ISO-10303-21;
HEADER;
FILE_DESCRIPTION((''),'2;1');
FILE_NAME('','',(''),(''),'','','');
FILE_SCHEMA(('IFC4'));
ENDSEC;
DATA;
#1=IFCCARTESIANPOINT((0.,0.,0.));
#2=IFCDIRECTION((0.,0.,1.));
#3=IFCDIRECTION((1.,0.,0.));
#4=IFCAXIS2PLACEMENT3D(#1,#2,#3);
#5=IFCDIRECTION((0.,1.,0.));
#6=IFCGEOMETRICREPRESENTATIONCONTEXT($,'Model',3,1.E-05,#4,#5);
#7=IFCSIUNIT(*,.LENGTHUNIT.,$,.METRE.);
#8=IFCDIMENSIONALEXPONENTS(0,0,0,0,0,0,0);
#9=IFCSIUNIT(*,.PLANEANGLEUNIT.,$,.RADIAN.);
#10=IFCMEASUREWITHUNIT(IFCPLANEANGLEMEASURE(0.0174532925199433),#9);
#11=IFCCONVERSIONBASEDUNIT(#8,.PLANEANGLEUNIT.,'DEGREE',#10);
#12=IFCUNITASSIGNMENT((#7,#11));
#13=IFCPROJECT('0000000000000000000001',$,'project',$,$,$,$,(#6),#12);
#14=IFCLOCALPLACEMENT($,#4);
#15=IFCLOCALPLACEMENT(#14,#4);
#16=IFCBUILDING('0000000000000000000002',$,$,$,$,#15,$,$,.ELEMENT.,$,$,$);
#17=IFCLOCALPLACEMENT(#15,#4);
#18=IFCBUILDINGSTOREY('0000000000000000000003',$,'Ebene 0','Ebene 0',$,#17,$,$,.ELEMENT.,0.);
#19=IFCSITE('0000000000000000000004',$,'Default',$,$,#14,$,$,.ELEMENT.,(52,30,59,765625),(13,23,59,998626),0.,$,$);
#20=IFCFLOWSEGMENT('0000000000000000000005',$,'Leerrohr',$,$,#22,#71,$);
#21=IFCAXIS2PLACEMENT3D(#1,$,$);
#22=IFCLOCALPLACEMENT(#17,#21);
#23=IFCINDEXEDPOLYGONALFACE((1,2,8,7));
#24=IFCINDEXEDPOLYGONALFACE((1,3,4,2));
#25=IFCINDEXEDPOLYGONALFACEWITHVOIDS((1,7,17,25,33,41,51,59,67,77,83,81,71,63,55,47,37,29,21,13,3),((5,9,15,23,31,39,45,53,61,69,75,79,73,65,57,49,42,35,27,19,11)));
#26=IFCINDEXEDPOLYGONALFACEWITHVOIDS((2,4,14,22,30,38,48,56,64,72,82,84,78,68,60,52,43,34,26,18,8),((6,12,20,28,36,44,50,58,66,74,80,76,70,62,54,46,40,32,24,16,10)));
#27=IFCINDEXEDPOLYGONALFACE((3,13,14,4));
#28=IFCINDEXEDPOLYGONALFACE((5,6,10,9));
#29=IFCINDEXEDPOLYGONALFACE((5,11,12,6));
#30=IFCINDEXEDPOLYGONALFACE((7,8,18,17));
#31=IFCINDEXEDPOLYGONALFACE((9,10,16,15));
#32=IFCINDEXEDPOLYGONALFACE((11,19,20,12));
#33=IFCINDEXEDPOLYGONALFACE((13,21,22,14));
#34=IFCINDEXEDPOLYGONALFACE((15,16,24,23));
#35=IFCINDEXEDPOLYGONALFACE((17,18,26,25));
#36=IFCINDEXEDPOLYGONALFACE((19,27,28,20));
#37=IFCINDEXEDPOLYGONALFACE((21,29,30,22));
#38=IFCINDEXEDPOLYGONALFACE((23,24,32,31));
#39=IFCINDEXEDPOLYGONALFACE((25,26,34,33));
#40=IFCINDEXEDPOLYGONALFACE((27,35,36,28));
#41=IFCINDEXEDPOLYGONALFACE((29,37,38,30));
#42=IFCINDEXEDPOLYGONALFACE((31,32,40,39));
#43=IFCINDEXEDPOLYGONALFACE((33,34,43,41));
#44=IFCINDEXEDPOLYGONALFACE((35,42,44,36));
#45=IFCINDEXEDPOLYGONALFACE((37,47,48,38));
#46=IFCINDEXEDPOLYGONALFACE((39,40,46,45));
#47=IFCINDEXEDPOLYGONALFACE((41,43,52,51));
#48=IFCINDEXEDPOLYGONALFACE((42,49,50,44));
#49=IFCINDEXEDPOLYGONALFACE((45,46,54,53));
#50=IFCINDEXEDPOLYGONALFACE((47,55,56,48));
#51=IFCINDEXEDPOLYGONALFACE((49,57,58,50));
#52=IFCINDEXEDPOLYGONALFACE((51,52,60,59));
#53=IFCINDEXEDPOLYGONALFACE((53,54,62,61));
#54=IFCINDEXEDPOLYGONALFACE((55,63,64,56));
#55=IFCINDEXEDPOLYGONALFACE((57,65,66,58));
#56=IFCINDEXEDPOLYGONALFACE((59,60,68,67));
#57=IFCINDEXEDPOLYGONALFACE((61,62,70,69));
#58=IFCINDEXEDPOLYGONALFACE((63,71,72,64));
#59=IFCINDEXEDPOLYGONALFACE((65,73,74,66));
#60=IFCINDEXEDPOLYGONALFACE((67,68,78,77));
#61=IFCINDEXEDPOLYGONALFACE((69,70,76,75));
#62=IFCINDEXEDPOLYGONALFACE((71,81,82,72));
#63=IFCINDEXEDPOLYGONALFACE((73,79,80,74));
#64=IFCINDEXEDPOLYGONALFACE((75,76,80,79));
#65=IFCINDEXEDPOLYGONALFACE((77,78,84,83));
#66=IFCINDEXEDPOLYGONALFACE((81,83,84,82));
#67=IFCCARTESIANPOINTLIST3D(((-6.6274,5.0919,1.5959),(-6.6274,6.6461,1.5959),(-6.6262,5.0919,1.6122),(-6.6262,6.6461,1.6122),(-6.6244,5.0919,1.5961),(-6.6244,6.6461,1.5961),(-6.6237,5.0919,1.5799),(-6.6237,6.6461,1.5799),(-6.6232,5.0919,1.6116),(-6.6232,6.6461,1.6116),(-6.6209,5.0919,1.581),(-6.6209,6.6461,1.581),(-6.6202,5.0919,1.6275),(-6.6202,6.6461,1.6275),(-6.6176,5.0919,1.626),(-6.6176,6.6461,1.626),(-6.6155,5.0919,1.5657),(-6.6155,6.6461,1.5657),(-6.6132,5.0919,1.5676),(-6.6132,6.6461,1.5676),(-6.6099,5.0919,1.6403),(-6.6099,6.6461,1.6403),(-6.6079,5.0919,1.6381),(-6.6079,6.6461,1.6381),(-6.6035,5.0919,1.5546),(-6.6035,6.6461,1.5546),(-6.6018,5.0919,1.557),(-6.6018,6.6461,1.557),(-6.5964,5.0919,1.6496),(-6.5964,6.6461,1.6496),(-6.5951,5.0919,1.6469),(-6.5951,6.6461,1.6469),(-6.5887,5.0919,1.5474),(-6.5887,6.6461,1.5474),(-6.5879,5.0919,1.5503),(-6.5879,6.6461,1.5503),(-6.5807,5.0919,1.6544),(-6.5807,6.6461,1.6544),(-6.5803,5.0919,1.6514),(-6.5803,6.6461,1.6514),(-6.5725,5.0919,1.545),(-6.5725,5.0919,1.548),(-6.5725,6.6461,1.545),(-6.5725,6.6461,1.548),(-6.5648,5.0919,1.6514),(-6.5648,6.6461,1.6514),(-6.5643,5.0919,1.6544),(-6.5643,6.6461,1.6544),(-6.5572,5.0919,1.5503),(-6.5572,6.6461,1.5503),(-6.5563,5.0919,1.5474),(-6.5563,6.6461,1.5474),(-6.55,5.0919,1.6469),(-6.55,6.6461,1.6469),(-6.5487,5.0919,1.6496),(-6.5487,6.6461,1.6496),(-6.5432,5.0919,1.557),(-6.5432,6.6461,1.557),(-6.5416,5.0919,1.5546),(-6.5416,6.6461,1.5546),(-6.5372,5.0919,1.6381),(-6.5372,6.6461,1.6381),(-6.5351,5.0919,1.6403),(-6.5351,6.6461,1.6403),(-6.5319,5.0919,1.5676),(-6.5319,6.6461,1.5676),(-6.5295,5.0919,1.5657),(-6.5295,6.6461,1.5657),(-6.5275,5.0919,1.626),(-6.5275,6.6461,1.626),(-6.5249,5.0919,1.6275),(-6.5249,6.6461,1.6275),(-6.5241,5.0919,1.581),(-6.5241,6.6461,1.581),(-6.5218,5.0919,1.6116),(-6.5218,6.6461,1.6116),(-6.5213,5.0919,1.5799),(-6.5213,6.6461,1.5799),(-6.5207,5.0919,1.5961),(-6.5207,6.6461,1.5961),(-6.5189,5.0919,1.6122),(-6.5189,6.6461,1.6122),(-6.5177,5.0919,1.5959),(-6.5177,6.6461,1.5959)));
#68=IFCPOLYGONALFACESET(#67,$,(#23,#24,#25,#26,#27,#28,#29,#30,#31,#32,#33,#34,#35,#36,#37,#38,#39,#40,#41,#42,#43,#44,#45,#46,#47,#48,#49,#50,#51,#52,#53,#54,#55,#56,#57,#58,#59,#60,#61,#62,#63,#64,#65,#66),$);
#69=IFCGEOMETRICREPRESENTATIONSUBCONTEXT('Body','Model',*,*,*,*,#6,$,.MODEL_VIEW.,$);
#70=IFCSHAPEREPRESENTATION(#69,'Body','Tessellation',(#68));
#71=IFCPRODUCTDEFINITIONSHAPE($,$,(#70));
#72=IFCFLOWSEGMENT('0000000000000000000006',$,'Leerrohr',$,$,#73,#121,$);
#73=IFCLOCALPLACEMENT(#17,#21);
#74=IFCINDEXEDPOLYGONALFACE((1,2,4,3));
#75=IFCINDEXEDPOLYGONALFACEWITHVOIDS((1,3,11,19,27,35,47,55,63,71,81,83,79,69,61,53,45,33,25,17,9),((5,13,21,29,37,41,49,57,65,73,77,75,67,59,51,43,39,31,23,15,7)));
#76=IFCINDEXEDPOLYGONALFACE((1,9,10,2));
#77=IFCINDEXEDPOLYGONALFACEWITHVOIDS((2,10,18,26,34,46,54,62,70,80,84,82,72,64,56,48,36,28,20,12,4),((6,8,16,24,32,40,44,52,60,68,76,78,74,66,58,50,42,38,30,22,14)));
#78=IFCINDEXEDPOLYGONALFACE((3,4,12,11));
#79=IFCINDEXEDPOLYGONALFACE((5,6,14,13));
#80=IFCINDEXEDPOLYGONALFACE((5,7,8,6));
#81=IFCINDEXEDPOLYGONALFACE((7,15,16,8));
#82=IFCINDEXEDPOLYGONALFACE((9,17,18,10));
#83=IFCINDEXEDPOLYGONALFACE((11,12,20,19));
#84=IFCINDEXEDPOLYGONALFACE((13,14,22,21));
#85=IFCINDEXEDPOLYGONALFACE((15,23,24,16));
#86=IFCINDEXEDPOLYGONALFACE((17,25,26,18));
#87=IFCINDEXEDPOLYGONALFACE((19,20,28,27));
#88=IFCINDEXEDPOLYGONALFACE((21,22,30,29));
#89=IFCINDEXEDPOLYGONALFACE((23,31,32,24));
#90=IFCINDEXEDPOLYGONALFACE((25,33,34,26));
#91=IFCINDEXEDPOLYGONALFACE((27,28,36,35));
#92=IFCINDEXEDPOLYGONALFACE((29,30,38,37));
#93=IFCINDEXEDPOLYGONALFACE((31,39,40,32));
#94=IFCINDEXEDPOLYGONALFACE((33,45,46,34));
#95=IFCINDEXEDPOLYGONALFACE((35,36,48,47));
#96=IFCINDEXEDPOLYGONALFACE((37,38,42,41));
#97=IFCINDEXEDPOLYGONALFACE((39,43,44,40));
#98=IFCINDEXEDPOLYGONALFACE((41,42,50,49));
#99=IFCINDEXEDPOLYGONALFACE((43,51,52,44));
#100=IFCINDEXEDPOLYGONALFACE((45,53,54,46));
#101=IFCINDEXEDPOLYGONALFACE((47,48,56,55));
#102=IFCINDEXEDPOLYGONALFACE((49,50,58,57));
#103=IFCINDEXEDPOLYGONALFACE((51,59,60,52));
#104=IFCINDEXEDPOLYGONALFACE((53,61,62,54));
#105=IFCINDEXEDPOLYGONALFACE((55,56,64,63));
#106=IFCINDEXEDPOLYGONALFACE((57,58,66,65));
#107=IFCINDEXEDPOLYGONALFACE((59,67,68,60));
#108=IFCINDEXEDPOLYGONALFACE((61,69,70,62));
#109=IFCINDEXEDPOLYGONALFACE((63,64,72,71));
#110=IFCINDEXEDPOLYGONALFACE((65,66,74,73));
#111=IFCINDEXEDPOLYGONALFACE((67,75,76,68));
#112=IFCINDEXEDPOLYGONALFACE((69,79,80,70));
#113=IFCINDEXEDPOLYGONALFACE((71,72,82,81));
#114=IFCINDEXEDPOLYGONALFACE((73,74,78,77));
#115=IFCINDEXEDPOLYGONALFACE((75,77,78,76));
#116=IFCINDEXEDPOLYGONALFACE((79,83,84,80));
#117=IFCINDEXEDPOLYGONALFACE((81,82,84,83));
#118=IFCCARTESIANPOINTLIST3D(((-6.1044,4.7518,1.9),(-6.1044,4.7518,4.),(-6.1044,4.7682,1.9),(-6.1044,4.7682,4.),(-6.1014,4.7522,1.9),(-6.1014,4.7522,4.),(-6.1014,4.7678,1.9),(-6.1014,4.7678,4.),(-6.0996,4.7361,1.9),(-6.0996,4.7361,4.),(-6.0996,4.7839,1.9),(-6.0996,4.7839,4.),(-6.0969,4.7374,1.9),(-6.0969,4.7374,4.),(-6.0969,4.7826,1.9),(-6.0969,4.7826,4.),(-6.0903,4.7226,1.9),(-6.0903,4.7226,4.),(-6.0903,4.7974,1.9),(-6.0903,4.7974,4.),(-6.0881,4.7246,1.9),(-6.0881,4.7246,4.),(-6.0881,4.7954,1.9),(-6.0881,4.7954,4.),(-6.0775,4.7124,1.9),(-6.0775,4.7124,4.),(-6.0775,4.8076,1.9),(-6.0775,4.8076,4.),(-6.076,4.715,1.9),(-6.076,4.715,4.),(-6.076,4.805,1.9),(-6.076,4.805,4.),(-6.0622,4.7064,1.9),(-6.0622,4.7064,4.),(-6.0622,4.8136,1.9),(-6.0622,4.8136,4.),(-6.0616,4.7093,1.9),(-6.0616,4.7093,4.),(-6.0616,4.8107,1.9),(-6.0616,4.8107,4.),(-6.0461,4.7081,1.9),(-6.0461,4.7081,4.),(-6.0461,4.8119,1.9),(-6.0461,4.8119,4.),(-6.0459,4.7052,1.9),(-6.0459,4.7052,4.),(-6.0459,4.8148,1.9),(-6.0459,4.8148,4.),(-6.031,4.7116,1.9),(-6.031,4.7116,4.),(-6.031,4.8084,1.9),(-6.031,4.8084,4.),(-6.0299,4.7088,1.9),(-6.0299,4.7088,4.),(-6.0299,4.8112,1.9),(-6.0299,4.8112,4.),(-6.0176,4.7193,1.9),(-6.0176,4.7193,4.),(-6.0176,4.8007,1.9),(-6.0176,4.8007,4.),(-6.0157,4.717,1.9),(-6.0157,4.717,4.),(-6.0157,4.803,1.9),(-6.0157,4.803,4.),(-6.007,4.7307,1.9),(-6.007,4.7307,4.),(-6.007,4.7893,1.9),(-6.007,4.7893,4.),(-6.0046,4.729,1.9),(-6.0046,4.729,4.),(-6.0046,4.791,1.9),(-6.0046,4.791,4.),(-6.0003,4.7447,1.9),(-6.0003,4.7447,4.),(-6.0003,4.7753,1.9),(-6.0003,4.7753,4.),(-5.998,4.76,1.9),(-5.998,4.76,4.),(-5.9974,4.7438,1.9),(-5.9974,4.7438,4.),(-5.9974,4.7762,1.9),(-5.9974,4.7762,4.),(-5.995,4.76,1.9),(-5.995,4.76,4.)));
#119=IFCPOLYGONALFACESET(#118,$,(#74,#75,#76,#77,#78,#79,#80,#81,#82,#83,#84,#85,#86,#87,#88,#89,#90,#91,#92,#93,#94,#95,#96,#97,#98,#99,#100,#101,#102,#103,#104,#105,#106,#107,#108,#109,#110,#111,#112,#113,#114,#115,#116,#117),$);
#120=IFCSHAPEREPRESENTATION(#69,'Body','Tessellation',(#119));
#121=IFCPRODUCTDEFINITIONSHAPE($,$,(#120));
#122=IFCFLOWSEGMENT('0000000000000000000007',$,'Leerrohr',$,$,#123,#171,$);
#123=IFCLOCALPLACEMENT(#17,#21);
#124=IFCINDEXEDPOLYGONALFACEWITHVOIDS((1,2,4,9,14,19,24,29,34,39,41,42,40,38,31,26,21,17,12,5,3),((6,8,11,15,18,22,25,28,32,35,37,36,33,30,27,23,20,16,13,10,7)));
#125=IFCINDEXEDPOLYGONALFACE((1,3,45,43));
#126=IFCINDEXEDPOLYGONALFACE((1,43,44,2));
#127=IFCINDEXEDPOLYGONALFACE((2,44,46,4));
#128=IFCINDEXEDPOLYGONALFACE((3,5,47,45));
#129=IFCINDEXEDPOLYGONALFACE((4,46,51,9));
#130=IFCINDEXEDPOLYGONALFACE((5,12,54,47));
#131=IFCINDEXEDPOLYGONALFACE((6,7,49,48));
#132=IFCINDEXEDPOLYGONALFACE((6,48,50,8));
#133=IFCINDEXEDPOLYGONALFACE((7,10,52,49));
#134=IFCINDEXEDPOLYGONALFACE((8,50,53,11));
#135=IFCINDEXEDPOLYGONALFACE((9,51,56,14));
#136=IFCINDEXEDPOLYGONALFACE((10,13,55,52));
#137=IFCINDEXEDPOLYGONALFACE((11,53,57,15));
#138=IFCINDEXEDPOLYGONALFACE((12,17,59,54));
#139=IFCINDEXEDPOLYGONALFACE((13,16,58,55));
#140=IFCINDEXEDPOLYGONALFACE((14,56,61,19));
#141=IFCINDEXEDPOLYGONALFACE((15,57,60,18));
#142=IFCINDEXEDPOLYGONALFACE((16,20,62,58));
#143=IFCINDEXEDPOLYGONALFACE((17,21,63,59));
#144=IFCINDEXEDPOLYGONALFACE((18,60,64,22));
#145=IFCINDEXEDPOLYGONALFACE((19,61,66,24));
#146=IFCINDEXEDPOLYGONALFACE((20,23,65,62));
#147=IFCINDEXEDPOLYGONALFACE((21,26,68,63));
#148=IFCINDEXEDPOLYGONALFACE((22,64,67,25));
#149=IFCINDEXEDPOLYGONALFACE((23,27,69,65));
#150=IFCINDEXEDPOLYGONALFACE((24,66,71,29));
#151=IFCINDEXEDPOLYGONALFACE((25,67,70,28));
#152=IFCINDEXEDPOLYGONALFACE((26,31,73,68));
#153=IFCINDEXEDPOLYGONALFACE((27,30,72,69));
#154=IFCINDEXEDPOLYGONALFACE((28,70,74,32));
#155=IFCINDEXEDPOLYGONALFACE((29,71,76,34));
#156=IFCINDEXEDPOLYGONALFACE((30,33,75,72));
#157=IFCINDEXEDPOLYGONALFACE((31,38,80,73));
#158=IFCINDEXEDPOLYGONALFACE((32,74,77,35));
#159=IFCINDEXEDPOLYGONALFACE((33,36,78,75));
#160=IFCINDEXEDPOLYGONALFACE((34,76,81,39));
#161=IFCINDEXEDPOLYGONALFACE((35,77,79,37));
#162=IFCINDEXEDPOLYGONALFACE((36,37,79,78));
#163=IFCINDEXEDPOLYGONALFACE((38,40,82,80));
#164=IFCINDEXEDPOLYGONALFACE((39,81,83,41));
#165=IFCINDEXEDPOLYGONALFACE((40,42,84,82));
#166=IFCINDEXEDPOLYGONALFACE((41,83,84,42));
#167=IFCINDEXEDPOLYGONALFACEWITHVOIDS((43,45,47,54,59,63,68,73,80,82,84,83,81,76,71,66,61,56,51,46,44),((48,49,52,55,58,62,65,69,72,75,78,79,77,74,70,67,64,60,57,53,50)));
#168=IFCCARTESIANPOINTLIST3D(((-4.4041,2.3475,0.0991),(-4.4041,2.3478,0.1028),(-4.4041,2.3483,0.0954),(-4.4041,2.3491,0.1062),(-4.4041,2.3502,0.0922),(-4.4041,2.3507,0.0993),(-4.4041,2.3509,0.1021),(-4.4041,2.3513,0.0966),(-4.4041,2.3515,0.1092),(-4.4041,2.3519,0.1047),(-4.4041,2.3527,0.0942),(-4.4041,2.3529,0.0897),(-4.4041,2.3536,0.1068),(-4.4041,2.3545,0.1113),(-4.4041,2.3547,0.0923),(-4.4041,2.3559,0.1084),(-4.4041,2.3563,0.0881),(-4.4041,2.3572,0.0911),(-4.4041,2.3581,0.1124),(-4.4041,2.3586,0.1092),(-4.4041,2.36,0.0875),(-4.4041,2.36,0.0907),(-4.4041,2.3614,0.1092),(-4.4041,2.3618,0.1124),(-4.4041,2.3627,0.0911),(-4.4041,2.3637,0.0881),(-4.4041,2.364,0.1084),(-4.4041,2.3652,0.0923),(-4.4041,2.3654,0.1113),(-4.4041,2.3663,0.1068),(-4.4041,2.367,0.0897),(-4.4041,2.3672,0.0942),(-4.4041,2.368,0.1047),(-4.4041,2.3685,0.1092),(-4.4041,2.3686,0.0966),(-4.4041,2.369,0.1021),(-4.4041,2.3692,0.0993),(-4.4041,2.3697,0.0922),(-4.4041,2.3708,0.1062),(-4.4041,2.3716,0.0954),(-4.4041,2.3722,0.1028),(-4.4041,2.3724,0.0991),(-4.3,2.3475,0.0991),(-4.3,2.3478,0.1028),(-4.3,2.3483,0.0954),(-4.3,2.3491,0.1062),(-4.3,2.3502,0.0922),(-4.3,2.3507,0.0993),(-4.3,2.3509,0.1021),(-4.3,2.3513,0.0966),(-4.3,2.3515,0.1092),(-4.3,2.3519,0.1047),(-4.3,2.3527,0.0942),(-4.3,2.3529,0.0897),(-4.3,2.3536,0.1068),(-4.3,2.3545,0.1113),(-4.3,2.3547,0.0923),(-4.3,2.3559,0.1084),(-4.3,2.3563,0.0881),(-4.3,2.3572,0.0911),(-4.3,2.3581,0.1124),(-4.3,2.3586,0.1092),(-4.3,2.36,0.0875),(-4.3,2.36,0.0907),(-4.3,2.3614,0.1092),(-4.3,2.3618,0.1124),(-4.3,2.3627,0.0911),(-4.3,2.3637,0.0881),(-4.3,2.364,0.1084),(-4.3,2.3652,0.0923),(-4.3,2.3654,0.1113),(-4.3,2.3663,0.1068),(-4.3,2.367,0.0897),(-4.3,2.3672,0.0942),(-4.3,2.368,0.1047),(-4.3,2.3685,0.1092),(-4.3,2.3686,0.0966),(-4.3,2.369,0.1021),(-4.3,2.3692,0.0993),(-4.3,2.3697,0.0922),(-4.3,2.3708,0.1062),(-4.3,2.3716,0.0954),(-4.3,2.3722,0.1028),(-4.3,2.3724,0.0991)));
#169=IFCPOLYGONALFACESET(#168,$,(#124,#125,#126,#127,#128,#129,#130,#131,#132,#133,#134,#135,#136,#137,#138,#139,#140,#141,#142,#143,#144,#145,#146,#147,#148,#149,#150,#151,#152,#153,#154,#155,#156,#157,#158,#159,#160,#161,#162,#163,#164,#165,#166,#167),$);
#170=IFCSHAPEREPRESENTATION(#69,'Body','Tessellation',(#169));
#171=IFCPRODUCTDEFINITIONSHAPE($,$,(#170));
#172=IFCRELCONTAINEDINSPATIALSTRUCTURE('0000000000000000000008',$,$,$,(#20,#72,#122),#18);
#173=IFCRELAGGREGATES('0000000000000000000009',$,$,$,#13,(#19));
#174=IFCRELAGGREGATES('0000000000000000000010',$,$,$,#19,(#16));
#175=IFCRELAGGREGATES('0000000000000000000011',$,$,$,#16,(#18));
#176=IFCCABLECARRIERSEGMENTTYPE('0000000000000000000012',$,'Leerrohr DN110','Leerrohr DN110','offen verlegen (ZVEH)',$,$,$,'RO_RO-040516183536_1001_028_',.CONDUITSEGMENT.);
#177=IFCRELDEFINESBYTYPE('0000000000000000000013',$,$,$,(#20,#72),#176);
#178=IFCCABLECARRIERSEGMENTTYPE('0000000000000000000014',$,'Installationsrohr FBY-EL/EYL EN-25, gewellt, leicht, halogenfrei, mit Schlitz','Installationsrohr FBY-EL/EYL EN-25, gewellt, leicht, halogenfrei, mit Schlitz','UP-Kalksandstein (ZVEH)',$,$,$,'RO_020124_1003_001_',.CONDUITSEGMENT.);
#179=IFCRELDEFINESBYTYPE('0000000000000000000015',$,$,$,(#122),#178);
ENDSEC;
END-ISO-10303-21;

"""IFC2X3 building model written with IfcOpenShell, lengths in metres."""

from ifc_helpers import new_model, entity, si_unit, converted_unit, direction, frame, origin_with_axes, origin_2d_with_axis, place, context, subcontext, project, spatial, hollow_circle, extrude, type_object, element, save


model = new_model("IFC2X3")

# Units and contexts
model_context = context("Model", 3, precision=1e-05, world=origin_with_axes(), true_north=direction((0.0, 1.0, 0.0)))
body_context = subcontext(model_context, "Body", "Model", "MODEL_VIEW")
ifc_project = project(units=[si_unit("LENGTHUNIT", "METRE"), converted_unit("PLANEANGLEUNIT", "DEGREE", entity("IfcPlaneAngleMeasure", 0.0174532925199433), si_unit("PLANEANGLEUNIT", "RADIAN"), dimensions=[0, 0, 0, 0, 0, 0, 0])], contexts=[model_context])

# Site, building, storey
site_placement = place(None, origin_with_axes())
site = spatial("IfcSite", under=ifc_project, at=site_placement, Name="Default", CompositionType="ELEMENT", RefLatitude=(52, 30, 59, 765625), RefLongitude=(13, 23, 59, 998626), RefElevation=0.0)
building_placement = place(site_placement, origin_with_axes())
building = spatial("IfcBuilding", under=site, at=building_placement, CompositionType="ELEMENT")
storey_placement = place(building_placement, origin_with_axes())
storey = spatial("IfcBuildingStorey", under=building, at=storey_placement, Name="Ebene 0", Description="Ebene 0", CompositionType="ELEMENT", Elevation=0.0)

# Flow segments
cable_carrier_segment_type_1 = type_object("IfcCableCarrierSegmentType", Name="Leerrohr DN110", Description="Leerrohr DN110", ApplicableOccurrence="offen verlegen (ZVEH)", ElementType="RO_RO-040516183536_1001_028_", PredefinedType="CONDUITSEGMENT")
flow_segment_1_placement = place(storey_placement, frame((-6.5725, 5.0919, 1.6), z_axis=(0.0, 0.0, 1.0), x_axis=(0.0, 1.0, 0.0)))
element("IfcFlowSegment", 1, at=flow_segment_1_placement, inside=storey, type_object=cable_carrier_segment_type_1, Name="Leerrohr", context=body_context, shape_type="SweptSolid", body=[
    extrude(hollow_circle(Radius=0.055, WallThickness=0.003, at=origin_2d_with_axis()), frame((0.0, 0.0, 0.0), z_axis=(1.0, 0.0, 0.0), x_axis=(0.0, 0.0, -1.0)), (0.0, 0.0, 1.0), 1.5543),
])
flow_segment_2_placement = place(storey_placement, frame((-6.05, 4.76, 1.9), z_axis=(-1.0, 0.0, 0.0), x_axis=(0.0, 0.0, 1.0)))
element("IfcFlowSegment", 2, at=flow_segment_2_placement, inside=storey, type_object=cable_carrier_segment_type_1, Name="Leerrohr", context=body_context, shape_type="SweptSolid", body=[
    extrude(hollow_circle(Radius=0.055, WallThickness=0.003, at=origin_2d_with_axis()), frame((0.0, 0.0, 0.0), z_axis=(1.0, 0.0, 0.0), x_axis=(0.0, 0.0, -1.0)), (0.0, 0.0, 1.0), 2.1),
])
cable_carrier_segment_type_2 = type_object("IfcCableCarrierSegmentType", Name="Installationsrohr FBY-EL/EYL EN-25, gewellt, leicht, halogenfrei, mit Schlitz", Description="Installationsrohr FBY-EL/EYL EN-25, gewellt, leicht, halogenfrei, mit Schlitz", ApplicableOccurrence="UP-Kalksandstein (ZVEH)", ElementType="RO_020124_1003_001_", PredefinedType="CONDUITSEGMENT")
flow_segment_3_placement = place(storey_placement, frame((-4.4041, 2.36, 0.1), z_axis=(0.0, 0.0, 1.0), x_axis=(1.0, 0.0, 0.0)))
element("IfcFlowSegment", 3, at=flow_segment_3_placement, inside=storey, type_object=cable_carrier_segment_type_2, Name="Leerrohr", context=body_context, shape_type="SweptSolid", body=[
    extrude(hollow_circle(Radius=0.0125, WallThickness=0.0032, at=origin_2d_with_axis()), frame((0.0, 0.0, 0.0), z_axis=(1.0, 0.0, 0.0), x_axis=(0.0, 0.0, -1.0)), (0.0, 0.0, 1.0), 0.1041),
])

save(model, "model.ifc")
